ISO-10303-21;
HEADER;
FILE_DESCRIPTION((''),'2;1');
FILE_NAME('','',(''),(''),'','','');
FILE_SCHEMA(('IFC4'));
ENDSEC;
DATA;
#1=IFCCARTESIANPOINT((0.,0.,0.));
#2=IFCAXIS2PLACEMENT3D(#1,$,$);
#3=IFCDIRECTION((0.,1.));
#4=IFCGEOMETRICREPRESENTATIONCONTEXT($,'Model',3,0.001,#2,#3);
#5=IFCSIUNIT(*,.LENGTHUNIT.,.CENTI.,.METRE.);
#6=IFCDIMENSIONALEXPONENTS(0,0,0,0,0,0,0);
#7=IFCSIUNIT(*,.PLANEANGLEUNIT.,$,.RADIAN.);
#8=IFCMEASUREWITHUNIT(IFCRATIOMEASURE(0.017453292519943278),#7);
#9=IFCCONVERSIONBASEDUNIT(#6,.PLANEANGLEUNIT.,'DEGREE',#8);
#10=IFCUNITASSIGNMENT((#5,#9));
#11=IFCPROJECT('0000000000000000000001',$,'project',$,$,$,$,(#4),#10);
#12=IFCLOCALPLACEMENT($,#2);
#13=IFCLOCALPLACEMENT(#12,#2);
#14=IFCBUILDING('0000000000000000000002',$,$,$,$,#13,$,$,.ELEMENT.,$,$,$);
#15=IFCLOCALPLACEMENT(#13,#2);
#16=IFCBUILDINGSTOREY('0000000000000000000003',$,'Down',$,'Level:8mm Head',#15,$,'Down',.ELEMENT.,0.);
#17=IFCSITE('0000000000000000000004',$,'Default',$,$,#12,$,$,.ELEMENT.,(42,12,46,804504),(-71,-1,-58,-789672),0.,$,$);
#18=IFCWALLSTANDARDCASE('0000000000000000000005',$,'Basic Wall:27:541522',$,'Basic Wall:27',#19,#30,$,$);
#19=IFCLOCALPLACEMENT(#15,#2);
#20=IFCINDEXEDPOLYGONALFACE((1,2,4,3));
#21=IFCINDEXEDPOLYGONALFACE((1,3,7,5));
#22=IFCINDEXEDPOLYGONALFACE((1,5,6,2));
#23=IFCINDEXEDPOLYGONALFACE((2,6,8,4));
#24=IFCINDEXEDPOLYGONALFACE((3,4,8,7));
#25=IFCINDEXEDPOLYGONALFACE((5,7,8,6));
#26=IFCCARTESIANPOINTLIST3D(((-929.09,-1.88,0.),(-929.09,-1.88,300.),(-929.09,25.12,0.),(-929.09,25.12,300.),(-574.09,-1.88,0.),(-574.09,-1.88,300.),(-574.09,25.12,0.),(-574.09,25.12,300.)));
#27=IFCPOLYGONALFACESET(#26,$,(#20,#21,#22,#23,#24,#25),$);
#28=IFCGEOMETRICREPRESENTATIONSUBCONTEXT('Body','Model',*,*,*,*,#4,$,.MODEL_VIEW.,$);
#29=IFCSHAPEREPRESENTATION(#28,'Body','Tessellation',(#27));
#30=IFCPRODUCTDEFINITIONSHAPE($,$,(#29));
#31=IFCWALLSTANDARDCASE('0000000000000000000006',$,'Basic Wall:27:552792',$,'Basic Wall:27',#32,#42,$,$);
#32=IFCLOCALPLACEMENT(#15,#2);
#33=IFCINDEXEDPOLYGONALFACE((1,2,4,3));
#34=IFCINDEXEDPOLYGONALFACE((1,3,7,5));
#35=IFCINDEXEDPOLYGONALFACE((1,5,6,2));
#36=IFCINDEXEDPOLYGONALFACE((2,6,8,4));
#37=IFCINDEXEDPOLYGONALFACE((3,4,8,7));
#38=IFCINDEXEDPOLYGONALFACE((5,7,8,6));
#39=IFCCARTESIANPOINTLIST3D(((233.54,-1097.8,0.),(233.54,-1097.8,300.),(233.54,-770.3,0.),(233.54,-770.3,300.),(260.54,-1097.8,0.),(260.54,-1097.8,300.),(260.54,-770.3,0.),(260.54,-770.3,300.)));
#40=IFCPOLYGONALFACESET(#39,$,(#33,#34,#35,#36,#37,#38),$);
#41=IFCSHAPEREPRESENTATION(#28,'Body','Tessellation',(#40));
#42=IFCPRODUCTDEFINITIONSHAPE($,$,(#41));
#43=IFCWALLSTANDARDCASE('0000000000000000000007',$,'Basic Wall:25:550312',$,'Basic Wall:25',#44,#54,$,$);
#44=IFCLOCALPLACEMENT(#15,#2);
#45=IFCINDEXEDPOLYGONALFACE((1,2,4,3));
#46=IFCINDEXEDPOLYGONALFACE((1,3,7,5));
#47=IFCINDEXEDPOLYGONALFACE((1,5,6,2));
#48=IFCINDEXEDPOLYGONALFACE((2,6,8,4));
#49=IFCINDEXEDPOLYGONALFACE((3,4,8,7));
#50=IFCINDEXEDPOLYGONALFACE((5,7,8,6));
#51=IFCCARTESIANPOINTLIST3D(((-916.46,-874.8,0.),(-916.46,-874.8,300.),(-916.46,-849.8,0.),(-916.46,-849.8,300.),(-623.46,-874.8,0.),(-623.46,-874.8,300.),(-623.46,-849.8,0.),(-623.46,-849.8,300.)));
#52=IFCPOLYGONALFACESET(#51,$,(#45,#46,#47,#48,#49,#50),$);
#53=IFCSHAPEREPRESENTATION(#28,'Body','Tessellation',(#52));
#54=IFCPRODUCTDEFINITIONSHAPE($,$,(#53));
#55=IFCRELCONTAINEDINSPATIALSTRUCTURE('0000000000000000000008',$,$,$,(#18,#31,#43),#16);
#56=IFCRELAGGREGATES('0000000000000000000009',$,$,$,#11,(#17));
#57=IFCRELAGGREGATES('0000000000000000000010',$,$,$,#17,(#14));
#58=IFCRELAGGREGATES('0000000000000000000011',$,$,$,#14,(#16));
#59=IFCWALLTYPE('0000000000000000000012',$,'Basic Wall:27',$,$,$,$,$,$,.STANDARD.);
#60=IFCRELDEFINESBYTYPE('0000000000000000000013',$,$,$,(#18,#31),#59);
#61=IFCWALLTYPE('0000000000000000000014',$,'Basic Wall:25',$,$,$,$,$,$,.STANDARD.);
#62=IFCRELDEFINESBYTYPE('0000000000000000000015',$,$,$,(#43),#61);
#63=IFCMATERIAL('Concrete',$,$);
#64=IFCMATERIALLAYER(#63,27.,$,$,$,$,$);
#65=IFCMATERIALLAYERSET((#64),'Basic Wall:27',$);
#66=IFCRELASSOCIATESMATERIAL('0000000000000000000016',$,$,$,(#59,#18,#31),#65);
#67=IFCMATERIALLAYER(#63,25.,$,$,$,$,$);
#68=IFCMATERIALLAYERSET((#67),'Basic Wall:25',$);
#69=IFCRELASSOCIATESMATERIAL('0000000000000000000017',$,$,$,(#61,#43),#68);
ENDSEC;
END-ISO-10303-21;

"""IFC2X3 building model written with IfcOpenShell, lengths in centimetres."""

from ifc_helpers import new_model, entity, si_unit, converted_unit, direction, frame, frame_2d, origin, place, context, subcontext, project, spatial, rectangle, extrude, material, layer, layer_set, layer_usage, type_object, element, save


model = new_model("IFC2X3")

# Units and contexts
model_context = context("Model", 3, precision=0.001, world=origin(), true_north=direction((0.0, 1.0)))
body_context = subcontext(model_context, "Body", "Model", "MODEL_VIEW")
ifc_project = project(units=[si_unit("LENGTHUNIT", "METRE", prefix="CENTI"), converted_unit("PLANEANGLEUNIT", "DEGREE", entity("IfcRatioMeasure", 0.017453292519943278), si_unit("PLANEANGLEUNIT", "RADIAN"), dimensions=[0, 0, 0, 0, 0, 0, 0])], contexts=[model_context])

# Site, building, storey
site_placement = place(None, origin())
site = spatial("IfcSite", under=ifc_project, at=site_placement, Name="Default", CompositionType="ELEMENT", RefLatitude=(42, 12, 46, 804504), RefLongitude=(-71, -1, -58, -789672), RefElevation=0.0)
building_placement = place(site_placement, origin())
building = spatial("IfcBuilding", under=site, at=building_placement, CompositionType="ELEMENT")
storey_placement = place(building_placement, origin())
storey = spatial("IfcBuildingStorey", under=building, at=storey_placement, Name="Down", ObjectType="Level:8mm Head", LongName="Down", CompositionType="ELEMENT", Elevation=0.0)

# Walls
ifc_material = material(Name="Concrete")
ifc_layer_1 = layer(ifc_material, 27.0)
ifc_layer_set_1 = layer_set([ifc_layer_1], Name="Basic Wall:27")
ifc_layer_usage_1 = layer_usage(ifc_layer_set_1, "AXIS2", "POSITIVE", -13.5)
wall_type_1 = type_object("IfcWallType", Name="Basic Wall:27", PredefinedType="STANDARD", material=ifc_layer_set_1)
wall_1_placement = place(storey_placement, frame((-929.09, 11.62, 0.0)))
element("IfcWallStandardCase", 1, at=wall_1_placement, inside=storey, type_object=wall_type_1, material=ifc_layer_usage_1, Name="Basic Wall:27:541522", ObjectType="Basic Wall:27", context=body_context, shape_type="SweptSolid", body=[
    extrude(rectangle(XDim=355.0, YDim=27.0, at=frame_2d((177.5, 0.0), x_axis=(-1.0, 0.0))), origin(), (0.0, 0.0, 1.0), 300.0),
])
ifc_layer_usage_2 = layer_usage(ifc_layer_set_1, "AXIS2", "POSITIVE", -13.5)
wall_2_placement = place(storey_placement, frame((247.04, -1097.8, 0.0), z_axis=(0.0, 0.0, 1.0), x_axis=(0.0, 1.0, 0.0)))
element("IfcWallStandardCase", 2, at=wall_2_placement, inside=storey, type_object=wall_type_1, material=ifc_layer_usage_2, Name="Basic Wall:27:552792", ObjectType="Basic Wall:27", context=body_context, shape_type="SweptSolid", body=[
    extrude(rectangle(XDim=327.5, YDim=27.0, at=frame_2d((163.75, 0.0), x_axis=(-1.0, 0.0))), origin(), (0.0, 0.0, 1.0), 300.0),
])
ifc_layer_2 = layer(ifc_material, 25.0)
ifc_layer_set_2 = layer_set([ifc_layer_2], Name="Basic Wall:25")
ifc_layer_usage_3 = layer_usage(ifc_layer_set_2, "AXIS2", "POSITIVE", -12.5)
wall_type_2 = type_object("IfcWallType", Name="Basic Wall:25", PredefinedType="STANDARD", material=ifc_layer_set_2)
wall_3_placement = place(storey_placement, frame((-916.46, -862.3, 0.0)))
element("IfcWallStandardCase", 3, at=wall_3_placement, inside=storey, type_object=wall_type_2, material=ifc_layer_usage_3, Name="Basic Wall:25:550312", ObjectType="Basic Wall:25", context=body_context, shape_type="SweptSolid", body=[
    extrude(rectangle(XDim=293.0, YDim=25.0, at=frame_2d((146.5, 0.0), x_axis=(-1.0, 0.0))), origin(), (0.0, 0.0, 1.0), 300.0),
])

save(model, "model.ifc")
